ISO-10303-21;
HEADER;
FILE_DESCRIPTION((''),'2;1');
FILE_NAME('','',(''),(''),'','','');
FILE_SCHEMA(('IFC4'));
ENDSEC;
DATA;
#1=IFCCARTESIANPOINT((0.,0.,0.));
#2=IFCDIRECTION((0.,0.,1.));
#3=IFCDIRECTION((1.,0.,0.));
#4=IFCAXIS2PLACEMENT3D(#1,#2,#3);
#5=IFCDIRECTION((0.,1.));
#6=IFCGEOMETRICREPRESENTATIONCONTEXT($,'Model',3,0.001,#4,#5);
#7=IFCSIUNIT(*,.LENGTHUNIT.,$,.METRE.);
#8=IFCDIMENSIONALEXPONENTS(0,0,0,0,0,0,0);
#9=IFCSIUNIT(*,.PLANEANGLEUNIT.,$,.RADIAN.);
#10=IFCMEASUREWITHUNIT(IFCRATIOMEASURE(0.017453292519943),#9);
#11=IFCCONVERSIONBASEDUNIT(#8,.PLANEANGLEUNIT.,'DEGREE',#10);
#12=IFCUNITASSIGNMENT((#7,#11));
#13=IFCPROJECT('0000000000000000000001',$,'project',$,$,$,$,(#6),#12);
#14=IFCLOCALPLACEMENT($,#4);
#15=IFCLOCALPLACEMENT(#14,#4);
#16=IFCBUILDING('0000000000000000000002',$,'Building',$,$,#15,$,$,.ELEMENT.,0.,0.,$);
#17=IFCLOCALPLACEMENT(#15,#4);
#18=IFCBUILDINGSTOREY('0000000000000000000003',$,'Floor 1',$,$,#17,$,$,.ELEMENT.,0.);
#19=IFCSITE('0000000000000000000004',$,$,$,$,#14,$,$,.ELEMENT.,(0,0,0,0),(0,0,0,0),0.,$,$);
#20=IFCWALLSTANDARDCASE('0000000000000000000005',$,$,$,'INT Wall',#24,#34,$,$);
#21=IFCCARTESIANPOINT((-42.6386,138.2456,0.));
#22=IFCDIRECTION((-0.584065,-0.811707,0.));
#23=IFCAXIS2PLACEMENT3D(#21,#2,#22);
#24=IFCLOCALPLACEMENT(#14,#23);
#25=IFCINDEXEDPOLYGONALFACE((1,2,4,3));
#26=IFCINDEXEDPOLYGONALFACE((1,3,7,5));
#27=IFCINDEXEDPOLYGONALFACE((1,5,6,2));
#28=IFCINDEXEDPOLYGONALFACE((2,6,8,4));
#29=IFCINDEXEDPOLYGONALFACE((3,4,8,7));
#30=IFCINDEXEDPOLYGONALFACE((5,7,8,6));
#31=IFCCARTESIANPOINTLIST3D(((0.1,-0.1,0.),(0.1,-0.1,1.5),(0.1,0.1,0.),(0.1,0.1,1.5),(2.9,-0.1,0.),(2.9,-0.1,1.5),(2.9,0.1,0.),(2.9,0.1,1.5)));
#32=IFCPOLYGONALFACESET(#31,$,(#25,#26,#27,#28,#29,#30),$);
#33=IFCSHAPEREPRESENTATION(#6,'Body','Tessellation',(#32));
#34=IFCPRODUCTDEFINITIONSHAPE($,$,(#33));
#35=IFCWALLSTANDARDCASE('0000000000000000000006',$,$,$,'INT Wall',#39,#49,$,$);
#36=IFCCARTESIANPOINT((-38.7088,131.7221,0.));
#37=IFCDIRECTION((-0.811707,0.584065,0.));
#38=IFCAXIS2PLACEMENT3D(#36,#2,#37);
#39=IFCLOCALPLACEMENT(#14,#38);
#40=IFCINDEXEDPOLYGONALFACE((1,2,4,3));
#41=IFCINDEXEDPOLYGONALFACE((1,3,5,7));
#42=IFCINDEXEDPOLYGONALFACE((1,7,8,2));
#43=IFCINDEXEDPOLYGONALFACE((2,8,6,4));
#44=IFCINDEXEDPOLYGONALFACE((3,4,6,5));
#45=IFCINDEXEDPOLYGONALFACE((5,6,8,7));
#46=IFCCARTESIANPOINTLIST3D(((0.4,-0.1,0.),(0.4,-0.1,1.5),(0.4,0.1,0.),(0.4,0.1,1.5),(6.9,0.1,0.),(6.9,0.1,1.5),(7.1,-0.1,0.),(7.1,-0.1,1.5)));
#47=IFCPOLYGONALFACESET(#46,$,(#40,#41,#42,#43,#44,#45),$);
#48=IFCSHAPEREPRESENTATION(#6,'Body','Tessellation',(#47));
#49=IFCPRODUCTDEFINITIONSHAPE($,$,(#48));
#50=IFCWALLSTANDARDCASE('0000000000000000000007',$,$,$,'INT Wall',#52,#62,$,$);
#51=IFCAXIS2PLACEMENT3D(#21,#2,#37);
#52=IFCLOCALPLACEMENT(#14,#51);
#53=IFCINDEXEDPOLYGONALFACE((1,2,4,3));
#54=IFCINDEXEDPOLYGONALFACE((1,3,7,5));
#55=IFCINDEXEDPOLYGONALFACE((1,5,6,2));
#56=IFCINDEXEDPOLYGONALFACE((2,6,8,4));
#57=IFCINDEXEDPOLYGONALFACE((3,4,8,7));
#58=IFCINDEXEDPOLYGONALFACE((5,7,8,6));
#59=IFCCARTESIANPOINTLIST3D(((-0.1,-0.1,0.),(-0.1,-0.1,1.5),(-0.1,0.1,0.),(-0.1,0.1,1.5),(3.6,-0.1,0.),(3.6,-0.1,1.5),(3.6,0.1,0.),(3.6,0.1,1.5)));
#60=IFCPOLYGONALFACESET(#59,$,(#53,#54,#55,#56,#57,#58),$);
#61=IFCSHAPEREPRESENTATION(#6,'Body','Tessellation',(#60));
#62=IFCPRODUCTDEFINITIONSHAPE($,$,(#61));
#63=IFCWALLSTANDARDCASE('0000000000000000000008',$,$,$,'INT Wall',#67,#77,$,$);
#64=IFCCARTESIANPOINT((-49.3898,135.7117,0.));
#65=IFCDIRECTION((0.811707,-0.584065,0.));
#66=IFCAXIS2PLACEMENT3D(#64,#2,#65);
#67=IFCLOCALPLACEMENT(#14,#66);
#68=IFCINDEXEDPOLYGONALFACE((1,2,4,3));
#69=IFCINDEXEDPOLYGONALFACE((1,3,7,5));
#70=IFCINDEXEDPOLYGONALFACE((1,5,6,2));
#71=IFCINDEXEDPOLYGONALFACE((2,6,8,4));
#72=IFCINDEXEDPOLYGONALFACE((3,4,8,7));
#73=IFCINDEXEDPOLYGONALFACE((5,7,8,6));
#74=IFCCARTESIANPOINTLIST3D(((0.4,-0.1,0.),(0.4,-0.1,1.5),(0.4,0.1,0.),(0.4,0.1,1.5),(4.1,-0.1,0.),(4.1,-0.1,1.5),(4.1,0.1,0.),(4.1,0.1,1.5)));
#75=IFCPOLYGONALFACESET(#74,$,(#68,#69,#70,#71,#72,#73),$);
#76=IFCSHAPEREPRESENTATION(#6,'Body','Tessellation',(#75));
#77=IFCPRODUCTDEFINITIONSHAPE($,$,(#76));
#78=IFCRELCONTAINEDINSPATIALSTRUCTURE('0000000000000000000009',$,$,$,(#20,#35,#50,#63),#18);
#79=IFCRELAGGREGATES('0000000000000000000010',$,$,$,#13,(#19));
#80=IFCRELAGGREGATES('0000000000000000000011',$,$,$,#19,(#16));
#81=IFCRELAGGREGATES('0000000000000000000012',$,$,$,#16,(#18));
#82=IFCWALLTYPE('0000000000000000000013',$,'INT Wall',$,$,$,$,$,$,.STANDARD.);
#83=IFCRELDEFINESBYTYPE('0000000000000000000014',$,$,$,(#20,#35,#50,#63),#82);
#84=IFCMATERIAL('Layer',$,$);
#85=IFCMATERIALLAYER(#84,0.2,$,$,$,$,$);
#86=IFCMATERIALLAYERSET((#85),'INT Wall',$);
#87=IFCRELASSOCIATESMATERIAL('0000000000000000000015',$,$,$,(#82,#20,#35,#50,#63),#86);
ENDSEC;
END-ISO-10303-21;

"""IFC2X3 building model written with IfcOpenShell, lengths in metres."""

from ifc_helpers import new_model, entity, si_unit, converted_unit, direction, frame, origin_with_axes, place, context, project, spatial, polyline, outline, extrude, material, layer, layer_set, layer_usage, type_object, element, save


model = new_model("IFC2X3")

# Units and contexts
model_context = context("Model", 3, precision=0.001, world=origin_with_axes(), true_north=direction((0.0, 1.0)))
ifc_project = project(units=[si_unit("LENGTHUNIT", "METRE"), converted_unit("PLANEANGLEUNIT", "DEGREE", entity("IfcRatioMeasure", 0.017453292519943), si_unit("PLANEANGLEUNIT", "RADIAN"), dimensions=[0, 0, 0, 0, 0, 0, 0])], contexts=[model_context])

# Site, building, storey
site_placement = place(None, origin_with_axes())
site = spatial("IfcSite", under=ifc_project, at=site_placement, CompositionType="ELEMENT", RefLatitude=(0, 0, 0, 0), RefLongitude=(0, 0, 0, 0), RefElevation=0.0)
building_placement = place(site_placement, origin_with_axes())
building = spatial("IfcBuilding", under=site, at=building_placement, Name="Building", CompositionType="ELEMENT", ElevationOfRefHeight=0.0, ElevationOfTerrain=0.0)
storey_placement = place(building_placement, origin_with_axes())
storey = spatial("IfcBuildingStorey", under=building, at=storey_placement, Name="Floor 1", CompositionType="ELEMENT", Elevation=0.0)

# Walls
ifc_material_1 = material(Name="Layer")
ifc_layer_1 = layer(ifc_material_1, 0.2)
ifc_layer_set_1 = layer_set([ifc_layer_1], Name="INT Wall")
ifc_layer_usage_1 = layer_usage(ifc_layer_set_1, "AXIS2", "POSITIVE", -0.1)
wall_type_1 = type_object("IfcWallType", Name="INT Wall", PredefinedType="STANDARD", material=ifc_layer_set_1)
wall_1_placement = place(site_placement, frame((-42.6386, 138.2456, 0.0), z_axis=(0.0, 0.0, 1.0), x_axis=(-0.584065, -0.811707, 0.0)))
element("IfcWallStandardCase", 1, at=wall_1_placement, inside=storey, type_object=wall_type_1, material=ifc_layer_usage_1, ObjectType="INT Wall", context=model_context, shape_type="SweptSolid", body=[
    extrude(outline(polyline([(2.9, -0.1), (2.9, 0.1), (0.1, 0.1), (0.1, -0.1), (2.9, -0.1)])), origin_with_axes(), (0.0, 0.0, 1.0), 1.5),
])
wall_2_placement = place(site_placement, frame((-38.7088, 131.7221, 0.0), z_axis=(0.0, 0.0, 1.0), x_axis=(-0.811707, 0.584065, 0.0)))
element("IfcWallStandardCase", 2, at=wall_2_placement, inside=storey, type_object=wall_type_1, material=ifc_layer_usage_1, ObjectType="INT Wall", context=model_context, shape_type="SweptSolid", body=[
    extrude(outline(polyline([(0.4, -0.1), (0.4, 0.1), (6.9, 0.1), (7.1, -0.1), (0.4, -0.1)])), origin_with_axes(), (0.0, 0.0, 1.0), 1.5),
])
wall_3_placement = place(site_placement, frame((-42.6386, 138.2456, 0.0), z_axis=(0.0, 0.0, 1.0), x_axis=(-0.811707, 0.584065, 0.0)))
element("IfcWallStandardCase", 3, at=wall_3_placement, inside=storey, type_object=wall_type_1, material=ifc_layer_usage_1, ObjectType="INT Wall", context=model_context, shape_type="SweptSolid", body=[
    extrude(outline(polyline([(3.6, 0.1), (3.6, -0.1), (-0.1, -0.1), (-0.1, 0.1), (3.6, 0.1)])), origin_with_axes(), (0.0, 0.0, 1.0), 1.5),
])
wall_4_placement = place(site_placement, frame((-49.3898, 135.7117, 0.0), z_axis=(0.0, 0.0, 1.0), x_axis=(0.811707, -0.584065, 0.0)))
element("IfcWallStandardCase", 4, at=wall_4_placement, inside=storey, type_object=wall_type_1, material=ifc_layer_usage_1, ObjectType="INT Wall", context=model_context, shape_type="SweptSolid", body=[
    extrude(outline(polyline([(0.4, -0.1), (0.4, 0.1), (4.1, 0.1), (4.1, -0.1), (0.4, -0.1)])), origin_with_axes(), (0.0, 0.0, 1.0), 1.5),
])

save(model, "model.ifc")
